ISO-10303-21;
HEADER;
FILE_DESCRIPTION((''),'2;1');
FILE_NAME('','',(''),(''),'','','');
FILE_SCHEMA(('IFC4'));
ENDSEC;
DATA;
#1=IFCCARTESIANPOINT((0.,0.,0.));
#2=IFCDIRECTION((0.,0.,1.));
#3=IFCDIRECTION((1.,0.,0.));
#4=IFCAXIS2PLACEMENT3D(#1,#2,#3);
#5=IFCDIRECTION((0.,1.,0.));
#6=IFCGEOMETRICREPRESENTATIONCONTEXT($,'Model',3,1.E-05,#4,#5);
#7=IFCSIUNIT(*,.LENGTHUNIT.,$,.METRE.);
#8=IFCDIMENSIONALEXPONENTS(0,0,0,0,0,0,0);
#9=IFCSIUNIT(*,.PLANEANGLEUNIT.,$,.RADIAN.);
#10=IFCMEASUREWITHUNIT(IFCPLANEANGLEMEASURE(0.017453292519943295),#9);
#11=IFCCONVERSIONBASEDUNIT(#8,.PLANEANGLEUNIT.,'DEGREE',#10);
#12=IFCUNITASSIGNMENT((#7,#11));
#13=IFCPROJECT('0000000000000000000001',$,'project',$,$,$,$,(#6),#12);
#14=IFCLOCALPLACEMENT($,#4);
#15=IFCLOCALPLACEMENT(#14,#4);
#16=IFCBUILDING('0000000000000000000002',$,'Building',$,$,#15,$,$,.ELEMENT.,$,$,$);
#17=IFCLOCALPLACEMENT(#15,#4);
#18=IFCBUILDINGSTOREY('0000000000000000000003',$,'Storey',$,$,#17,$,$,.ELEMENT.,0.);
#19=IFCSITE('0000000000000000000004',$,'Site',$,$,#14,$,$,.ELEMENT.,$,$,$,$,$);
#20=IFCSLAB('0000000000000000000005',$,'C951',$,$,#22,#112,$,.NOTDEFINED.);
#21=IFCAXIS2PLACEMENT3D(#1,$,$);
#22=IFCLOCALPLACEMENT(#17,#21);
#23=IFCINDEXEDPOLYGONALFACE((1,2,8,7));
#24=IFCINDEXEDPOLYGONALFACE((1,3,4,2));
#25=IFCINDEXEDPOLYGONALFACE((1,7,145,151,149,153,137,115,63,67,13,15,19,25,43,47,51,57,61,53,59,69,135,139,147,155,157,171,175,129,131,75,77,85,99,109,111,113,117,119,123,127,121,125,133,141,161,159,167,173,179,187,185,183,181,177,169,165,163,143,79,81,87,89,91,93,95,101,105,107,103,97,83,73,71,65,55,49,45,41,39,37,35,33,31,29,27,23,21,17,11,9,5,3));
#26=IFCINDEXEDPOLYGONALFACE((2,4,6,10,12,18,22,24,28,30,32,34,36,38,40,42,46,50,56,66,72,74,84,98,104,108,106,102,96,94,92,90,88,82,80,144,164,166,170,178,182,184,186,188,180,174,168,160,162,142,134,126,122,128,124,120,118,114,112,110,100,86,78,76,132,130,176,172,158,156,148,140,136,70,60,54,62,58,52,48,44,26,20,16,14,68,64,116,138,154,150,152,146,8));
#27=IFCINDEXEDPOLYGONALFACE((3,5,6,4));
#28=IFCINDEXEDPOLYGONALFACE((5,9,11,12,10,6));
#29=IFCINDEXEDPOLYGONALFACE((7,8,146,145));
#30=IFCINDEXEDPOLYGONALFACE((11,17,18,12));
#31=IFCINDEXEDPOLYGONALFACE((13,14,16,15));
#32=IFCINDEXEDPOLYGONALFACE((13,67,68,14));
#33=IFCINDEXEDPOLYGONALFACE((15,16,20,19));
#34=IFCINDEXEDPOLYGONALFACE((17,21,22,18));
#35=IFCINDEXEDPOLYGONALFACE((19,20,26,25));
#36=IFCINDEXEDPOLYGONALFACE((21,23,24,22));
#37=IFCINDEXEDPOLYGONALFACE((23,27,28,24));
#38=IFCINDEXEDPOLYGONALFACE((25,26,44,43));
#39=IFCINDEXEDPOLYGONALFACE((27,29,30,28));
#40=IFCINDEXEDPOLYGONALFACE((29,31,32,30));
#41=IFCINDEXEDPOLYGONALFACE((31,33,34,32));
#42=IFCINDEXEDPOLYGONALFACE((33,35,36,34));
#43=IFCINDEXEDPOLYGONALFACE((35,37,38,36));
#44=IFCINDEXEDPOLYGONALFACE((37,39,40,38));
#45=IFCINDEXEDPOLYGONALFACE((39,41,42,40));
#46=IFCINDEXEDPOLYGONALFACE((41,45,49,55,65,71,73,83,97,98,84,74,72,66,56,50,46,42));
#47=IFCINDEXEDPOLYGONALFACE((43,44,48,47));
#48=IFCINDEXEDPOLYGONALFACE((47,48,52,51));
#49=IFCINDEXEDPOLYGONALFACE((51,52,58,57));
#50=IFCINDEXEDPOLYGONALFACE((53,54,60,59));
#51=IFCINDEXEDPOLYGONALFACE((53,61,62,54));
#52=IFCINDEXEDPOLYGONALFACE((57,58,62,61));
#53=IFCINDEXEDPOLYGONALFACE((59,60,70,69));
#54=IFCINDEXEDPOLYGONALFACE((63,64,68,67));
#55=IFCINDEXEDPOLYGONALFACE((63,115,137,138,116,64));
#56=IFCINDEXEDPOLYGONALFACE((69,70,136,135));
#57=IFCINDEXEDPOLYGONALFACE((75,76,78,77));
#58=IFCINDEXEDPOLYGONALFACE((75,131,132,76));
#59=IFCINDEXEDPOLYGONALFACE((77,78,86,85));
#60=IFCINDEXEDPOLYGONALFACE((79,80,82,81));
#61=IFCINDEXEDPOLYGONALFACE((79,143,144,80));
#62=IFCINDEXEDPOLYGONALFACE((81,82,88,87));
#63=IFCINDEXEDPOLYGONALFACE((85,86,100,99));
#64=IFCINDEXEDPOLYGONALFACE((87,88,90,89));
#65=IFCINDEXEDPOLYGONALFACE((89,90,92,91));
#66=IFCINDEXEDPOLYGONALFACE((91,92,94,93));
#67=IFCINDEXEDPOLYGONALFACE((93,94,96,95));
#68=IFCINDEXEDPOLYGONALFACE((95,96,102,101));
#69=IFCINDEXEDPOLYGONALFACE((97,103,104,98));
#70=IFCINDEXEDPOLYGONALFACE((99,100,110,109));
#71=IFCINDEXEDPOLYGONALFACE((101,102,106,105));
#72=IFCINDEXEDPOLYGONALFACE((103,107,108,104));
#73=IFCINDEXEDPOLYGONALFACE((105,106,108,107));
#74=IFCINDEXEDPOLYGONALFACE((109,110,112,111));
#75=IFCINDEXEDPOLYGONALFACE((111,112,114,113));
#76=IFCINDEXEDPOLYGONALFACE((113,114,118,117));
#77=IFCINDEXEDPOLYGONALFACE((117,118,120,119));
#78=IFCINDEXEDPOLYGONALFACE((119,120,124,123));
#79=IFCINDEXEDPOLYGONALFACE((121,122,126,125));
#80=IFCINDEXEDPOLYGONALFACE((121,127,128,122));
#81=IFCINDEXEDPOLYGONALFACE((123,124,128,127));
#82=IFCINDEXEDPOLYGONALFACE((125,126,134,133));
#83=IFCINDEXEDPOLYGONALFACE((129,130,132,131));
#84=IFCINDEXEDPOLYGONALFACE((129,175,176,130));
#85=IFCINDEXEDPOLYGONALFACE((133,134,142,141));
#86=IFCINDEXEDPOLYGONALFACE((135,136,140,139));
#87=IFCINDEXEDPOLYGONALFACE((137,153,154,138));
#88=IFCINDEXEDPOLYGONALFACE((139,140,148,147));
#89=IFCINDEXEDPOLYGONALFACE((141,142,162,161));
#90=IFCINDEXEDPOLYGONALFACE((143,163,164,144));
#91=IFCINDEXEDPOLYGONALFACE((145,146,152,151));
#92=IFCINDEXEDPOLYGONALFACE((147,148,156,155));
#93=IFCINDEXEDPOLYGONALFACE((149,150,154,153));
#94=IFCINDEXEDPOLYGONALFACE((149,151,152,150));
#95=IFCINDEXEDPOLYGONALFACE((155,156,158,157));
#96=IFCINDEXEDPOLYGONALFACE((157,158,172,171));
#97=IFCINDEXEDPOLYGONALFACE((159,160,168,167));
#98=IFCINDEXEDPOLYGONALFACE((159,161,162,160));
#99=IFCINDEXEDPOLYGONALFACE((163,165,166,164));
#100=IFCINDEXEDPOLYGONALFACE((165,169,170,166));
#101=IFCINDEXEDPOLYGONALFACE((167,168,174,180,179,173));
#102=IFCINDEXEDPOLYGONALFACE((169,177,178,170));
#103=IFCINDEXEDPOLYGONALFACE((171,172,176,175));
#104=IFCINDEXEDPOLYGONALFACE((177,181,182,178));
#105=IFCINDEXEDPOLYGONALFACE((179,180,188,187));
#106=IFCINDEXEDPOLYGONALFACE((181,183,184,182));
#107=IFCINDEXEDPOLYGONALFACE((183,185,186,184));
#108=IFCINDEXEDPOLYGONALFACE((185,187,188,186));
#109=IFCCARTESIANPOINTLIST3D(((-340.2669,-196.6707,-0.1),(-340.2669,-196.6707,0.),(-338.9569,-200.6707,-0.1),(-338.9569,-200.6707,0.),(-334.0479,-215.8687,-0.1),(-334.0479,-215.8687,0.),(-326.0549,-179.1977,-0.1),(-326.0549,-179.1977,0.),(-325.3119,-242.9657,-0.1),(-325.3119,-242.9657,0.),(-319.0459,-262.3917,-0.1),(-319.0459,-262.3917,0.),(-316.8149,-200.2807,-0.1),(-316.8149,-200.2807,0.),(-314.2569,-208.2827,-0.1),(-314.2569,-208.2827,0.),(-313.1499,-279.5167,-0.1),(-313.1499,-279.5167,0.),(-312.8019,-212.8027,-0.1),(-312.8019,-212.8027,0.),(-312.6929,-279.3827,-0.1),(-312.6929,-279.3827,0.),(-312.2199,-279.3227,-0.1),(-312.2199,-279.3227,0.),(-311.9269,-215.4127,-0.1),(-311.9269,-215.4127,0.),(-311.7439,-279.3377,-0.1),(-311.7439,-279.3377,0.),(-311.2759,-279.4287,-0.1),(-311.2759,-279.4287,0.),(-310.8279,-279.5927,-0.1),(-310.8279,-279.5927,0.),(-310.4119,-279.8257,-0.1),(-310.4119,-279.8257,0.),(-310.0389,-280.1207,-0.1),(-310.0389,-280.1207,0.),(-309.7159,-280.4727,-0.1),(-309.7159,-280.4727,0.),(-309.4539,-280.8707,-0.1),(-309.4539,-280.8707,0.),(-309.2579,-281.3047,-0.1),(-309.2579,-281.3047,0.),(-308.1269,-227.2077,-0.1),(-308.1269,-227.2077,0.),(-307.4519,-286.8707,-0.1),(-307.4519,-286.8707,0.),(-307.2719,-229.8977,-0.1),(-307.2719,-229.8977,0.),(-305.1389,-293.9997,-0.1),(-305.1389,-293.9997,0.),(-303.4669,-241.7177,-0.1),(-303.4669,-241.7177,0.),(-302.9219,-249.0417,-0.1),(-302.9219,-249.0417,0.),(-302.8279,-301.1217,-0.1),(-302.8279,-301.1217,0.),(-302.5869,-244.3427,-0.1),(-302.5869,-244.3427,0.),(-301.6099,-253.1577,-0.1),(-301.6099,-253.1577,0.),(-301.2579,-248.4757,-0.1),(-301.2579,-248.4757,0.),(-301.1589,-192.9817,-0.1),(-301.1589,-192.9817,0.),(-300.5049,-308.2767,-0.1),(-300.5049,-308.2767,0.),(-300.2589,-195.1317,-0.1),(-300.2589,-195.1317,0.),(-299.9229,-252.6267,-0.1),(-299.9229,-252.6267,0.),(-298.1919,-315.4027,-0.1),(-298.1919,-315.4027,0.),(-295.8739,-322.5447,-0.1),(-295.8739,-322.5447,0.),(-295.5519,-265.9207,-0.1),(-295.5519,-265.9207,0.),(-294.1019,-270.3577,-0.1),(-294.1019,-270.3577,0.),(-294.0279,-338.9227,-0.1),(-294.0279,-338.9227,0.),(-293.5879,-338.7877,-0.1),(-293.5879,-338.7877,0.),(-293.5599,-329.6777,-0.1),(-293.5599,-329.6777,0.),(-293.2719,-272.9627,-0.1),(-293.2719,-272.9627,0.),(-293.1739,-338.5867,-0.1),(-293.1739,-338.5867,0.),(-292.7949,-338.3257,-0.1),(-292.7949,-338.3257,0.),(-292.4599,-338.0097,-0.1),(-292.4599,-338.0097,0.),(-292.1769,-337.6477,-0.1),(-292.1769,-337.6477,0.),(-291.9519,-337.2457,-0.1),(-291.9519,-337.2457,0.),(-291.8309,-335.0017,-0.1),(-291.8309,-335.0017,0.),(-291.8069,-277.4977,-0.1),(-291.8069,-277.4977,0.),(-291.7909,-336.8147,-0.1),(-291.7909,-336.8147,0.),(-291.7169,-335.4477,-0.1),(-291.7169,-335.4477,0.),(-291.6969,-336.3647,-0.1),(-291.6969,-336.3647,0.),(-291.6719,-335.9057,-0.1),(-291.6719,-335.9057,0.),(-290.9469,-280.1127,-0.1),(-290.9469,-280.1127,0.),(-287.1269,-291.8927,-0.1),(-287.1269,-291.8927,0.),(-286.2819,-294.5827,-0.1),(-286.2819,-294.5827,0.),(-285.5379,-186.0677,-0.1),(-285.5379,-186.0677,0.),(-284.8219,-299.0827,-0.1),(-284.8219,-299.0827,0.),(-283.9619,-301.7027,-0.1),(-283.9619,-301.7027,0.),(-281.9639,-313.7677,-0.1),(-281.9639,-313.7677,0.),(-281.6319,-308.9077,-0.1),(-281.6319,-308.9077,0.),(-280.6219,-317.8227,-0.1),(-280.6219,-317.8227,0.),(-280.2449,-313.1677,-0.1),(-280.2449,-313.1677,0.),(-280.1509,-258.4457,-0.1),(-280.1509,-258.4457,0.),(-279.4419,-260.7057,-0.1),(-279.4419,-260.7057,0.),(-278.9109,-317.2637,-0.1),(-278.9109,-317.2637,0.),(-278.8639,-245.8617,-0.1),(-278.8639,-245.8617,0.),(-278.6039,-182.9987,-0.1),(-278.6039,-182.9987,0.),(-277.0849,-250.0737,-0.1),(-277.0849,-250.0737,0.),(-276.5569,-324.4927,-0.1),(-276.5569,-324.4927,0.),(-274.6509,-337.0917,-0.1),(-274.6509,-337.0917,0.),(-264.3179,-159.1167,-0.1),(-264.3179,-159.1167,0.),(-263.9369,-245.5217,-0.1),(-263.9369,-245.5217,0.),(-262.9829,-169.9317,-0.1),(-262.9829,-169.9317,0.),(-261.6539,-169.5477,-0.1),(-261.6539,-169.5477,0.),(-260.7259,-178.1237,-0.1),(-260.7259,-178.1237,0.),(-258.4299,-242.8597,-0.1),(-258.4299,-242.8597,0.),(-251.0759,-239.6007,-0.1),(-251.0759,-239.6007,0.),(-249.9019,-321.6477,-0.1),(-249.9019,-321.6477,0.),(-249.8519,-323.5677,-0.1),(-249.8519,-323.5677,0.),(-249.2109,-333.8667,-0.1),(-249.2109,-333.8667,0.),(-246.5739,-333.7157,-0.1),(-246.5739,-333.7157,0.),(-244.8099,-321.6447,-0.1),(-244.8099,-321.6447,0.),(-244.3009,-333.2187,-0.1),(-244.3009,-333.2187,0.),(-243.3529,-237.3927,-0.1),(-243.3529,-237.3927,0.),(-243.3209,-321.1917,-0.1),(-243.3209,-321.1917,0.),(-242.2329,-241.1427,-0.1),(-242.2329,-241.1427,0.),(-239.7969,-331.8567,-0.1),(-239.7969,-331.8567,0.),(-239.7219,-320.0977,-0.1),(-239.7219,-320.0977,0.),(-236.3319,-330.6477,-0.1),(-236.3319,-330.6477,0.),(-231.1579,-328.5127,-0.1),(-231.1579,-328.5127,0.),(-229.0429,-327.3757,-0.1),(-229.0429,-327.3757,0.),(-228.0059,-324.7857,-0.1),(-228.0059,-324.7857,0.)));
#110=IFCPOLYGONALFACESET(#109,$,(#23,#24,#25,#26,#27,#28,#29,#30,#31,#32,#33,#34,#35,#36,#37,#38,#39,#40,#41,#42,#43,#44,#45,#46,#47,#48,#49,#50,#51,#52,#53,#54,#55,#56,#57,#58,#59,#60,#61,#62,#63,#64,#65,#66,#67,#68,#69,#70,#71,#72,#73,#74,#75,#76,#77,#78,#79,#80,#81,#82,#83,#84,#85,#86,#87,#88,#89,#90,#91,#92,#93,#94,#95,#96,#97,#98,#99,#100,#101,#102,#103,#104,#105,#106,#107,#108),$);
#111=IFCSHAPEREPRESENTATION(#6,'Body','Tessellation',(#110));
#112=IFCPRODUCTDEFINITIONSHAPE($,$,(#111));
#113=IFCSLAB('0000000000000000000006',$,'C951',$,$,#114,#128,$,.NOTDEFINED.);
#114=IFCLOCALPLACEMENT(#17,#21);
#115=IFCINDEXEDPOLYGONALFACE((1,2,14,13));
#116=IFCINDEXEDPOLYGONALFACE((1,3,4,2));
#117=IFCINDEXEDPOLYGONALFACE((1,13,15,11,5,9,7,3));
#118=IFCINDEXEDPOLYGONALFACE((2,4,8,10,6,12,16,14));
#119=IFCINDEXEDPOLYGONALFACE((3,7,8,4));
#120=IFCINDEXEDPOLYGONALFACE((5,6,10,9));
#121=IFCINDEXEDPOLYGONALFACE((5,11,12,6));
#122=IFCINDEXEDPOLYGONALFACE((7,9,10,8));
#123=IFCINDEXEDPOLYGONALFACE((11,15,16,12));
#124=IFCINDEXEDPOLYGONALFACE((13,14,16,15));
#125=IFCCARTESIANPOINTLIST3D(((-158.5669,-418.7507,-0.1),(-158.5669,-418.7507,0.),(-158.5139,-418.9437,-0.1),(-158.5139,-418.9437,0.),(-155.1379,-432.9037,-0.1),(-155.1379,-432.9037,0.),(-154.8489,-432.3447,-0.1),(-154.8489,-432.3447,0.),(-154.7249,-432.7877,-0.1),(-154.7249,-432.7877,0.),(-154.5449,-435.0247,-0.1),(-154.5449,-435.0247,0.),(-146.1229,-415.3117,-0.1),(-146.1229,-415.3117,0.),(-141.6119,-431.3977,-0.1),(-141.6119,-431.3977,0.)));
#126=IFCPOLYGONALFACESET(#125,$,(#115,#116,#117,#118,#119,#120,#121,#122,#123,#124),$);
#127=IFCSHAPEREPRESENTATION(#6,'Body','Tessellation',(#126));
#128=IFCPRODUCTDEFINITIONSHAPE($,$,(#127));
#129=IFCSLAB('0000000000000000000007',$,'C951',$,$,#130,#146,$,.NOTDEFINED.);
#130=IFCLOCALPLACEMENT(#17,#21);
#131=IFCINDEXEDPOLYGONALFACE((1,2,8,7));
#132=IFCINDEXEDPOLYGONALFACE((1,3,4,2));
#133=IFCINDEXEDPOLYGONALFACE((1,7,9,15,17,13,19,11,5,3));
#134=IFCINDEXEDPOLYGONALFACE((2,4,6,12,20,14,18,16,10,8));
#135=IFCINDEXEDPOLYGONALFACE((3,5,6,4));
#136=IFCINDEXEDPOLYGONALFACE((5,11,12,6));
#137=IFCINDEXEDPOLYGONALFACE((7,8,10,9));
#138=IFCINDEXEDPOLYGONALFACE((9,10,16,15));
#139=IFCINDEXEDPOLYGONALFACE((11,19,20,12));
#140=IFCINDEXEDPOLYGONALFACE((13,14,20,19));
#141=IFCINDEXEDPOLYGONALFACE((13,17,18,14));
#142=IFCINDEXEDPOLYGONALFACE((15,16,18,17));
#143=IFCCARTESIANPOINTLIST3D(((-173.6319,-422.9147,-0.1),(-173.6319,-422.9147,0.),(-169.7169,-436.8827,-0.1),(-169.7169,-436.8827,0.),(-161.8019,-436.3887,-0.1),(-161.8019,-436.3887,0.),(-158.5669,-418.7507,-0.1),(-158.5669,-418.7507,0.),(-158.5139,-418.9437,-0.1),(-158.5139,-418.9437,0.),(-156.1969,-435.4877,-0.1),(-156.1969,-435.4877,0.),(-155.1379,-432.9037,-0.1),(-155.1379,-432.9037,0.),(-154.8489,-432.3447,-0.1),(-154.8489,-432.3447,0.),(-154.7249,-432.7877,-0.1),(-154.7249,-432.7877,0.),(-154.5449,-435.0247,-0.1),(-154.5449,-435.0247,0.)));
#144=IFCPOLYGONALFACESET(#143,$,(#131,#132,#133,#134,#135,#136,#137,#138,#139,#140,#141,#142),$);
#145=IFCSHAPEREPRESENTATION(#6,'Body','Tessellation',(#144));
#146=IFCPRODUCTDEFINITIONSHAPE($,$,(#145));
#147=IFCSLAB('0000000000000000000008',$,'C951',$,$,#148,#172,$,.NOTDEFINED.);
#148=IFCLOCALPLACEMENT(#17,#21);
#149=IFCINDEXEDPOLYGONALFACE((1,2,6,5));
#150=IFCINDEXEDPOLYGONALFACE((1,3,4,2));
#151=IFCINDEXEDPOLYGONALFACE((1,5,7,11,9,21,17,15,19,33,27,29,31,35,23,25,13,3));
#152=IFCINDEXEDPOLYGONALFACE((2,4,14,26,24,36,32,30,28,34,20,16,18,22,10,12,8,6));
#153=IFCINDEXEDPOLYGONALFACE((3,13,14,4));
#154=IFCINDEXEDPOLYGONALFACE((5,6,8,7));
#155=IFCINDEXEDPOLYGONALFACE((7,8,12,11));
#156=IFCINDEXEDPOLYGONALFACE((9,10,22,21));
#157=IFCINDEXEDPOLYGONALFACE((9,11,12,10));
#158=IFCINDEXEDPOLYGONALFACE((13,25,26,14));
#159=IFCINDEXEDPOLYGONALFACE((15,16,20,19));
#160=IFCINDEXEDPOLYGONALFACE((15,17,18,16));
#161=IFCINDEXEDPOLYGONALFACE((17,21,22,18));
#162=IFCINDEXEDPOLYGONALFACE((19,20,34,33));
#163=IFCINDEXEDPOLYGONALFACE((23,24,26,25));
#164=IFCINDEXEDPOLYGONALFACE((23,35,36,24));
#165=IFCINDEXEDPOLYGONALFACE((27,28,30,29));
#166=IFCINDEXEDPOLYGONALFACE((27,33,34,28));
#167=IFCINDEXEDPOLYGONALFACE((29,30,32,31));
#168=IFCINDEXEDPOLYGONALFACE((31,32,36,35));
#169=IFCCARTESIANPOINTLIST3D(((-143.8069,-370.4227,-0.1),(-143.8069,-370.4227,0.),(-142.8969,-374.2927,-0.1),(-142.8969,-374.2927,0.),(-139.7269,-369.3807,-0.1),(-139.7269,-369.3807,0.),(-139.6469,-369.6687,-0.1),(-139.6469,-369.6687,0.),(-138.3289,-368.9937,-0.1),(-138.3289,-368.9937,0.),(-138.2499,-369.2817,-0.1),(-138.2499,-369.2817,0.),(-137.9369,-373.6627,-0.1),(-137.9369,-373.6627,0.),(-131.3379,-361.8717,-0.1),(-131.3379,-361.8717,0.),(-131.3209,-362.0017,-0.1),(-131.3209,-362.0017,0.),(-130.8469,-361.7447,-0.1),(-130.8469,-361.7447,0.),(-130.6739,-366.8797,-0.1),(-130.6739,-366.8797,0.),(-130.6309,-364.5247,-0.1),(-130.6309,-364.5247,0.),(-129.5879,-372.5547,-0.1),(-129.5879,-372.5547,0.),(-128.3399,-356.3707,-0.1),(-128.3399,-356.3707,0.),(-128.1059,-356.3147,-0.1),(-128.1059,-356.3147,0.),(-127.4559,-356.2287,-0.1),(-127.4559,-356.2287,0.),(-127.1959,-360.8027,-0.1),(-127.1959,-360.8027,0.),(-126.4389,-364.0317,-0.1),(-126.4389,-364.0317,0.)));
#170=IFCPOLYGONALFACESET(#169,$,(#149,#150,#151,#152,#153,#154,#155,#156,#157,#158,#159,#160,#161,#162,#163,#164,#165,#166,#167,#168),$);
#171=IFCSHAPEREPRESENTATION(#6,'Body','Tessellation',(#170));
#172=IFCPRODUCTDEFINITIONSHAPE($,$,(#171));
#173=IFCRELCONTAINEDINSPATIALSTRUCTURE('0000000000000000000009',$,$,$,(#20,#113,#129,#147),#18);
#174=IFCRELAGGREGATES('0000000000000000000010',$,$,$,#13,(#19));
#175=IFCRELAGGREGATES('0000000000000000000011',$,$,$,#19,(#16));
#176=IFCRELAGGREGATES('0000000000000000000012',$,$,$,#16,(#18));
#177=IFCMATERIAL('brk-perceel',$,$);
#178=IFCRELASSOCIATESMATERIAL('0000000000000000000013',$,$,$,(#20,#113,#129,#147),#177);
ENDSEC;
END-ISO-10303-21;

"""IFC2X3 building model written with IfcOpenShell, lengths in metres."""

from ifc_helpers import new_model, entity, si_unit, converted_unit, direction, frame, origin_with_axes, place, context, project, spatial, polyline, outline, extrude, material, element, save


model = new_model("IFC2X3")

# Units and contexts
model_context = context("Model", 3, precision=1e-05, world=origin_with_axes(), true_north=direction((0.0, 1.0, 0.0)))
ifc_project = project(units=[si_unit("LENGTHUNIT", "METRE"), converted_unit("PLANEANGLEUNIT", "DEGREE", entity("IfcPlaneAngleMeasure", 0.017453292519943295), si_unit("PLANEANGLEUNIT", "RADIAN"), dimensions=[0, 0, 0, 0, 0, 0, 0])], contexts=[model_context])

# Site, building, storey
site_placement = place(None, origin_with_axes())
site = spatial("IfcSite", under=ifc_project, at=site_placement, Name="Site", CompositionType="ELEMENT")
building_placement = place(site_placement, origin_with_axes())
building = spatial("IfcBuilding", under=site, at=building_placement, Name="Building", CompositionType="ELEMENT")
storey_placement = place(building_placement, origin_with_axes())
storey = spatial("IfcBuildingStorey", under=building, at=storey_placement, Name="Storey", CompositionType="ELEMENT", Elevation=0.0)

# Slabs
ifc_material = material(Name="brk-perceel")
slab_1_placement = place(storey_placement, frame((0.0, 0.0, -0.1), z_axis=(0.0, 0.0, 1.0), x_axis=(1.0, 0.0, 0.0)))
element("IfcSlab", 1, at=slab_1_placement, inside=storey, material=ifc_material, Name="C951", PredefinedType="NOTDEFINED", context=model_context, shape_type="SweptSolid", body=[
    extrude(outline(polyline([(-239.7219, -320.0977), (-228.0059, -324.7857), (-229.0429, -327.3757), (-231.1579, -328.5127), (-236.3319, -330.6477), (-239.7969, -331.8567), (-244.3009, -333.2187), (-246.5739, -333.7157), (-249.2109, -333.8667), (-274.6509, -337.0917), (-294.0279, -338.9227), (-293.5879, -338.7877), (-293.1739, -338.5867), (-292.7949, -338.3257), (-292.4599, -338.0097), (-292.1769, -337.6477), (-291.9519, -337.2457), (-291.7909, -336.8147), (-291.6969, -336.3647), (-291.6719, -335.9057), (-291.7169, -335.4477), (-291.8309, -335.0017), (-293.5599, -329.6777), (-295.8739, -322.5447), (-298.1919, -315.4027), (-300.5049, -308.2767), (-302.8279, -301.1217), (-305.1389, -293.9997), (-307.4519, -286.8707), (-309.2579, -281.3047), (-309.4539, -280.8707), (-309.7159, -280.4727), (-310.0389, -280.1207), (-310.4119, -279.8257), (-310.8279, -279.5927), (-311.2759, -279.4287), (-311.7439, -279.3377), (-312.2199, -279.3227), (-312.6929, -279.3827), (-313.1499, -279.5167), (-319.0459, -262.3917), (-325.3119, -242.9657), (-334.0479, -215.8687), (-338.9569, -200.6707), (-340.2669, -196.6707), (-326.0549, -179.1977), (-264.3179, -159.1167), (-261.6539, -169.5477), (-262.9829, -169.9317), (-260.7259, -178.1237), (-278.6039, -182.9987), (-285.5379, -186.0677), (-301.1589, -192.9817), (-300.2589, -195.1317), (-316.8149, -200.2807), (-314.2569, -208.2827), (-312.8019, -212.8027), (-311.9269, -215.4127), (-308.1269, -227.2077), (-307.2719, -229.8977), (-303.4669, -241.7177), (-302.5869, -244.3427), (-301.2579, -248.4757), (-302.9219, -249.0417), (-301.6099, -253.1577), (-299.9229, -252.6267), (-278.8639, -245.8617), (-277.0849, -250.0737), (-263.9369, -245.5217), (-258.4299, -242.8597), (-251.0759, -239.6007), (-243.3529, -237.3927), (-242.2329, -241.1427), (-280.1509, -258.4457), (-279.4419, -260.7057), (-295.5519, -265.9207), (-294.1019, -270.3577), (-293.2719, -272.9627), (-291.8069, -277.4977), (-290.9469, -280.1127), (-287.1269, -291.8927), (-286.2819, -294.5827), (-284.8219, -299.0827), (-283.9619, -301.7027), (-281.6319, -308.9077), (-280.2449, -313.1677), (-281.9639, -313.7677), (-280.6219, -317.8227), (-278.9109, -317.2637), (-276.5569, -324.4927), (-249.8519, -323.5677), (-249.9019, -321.6477), (-244.8099, -321.6447), (-243.3209, -321.1917), (-239.7219, -320.0977)])), origin_with_axes(), (0.0, 0.0, 1.0), 0.1),
])
slab_2_placement = place(storey_placement, frame((0.0, 0.0, -0.1), z_axis=(0.0, 0.0, 1.0), x_axis=(1.0, 0.0, 0.0)))
element("IfcSlab", 2, at=slab_2_placement, inside=storey, material=ifc_material, Name="C951", PredefinedType="NOTDEFINED", context=model_context, shape_type="SweptSolid", body=[
    extrude(outline(polyline([(-146.1229, -415.3117), (-141.6119, -431.3977), (-154.5449, -435.0247), (-155.1379, -432.9037), (-154.7249, -432.7877), (-154.8489, -432.3447), (-158.5139, -418.9437), (-158.5669, -418.7507), (-146.1229, -415.3117)])), origin_with_axes(), (0.0, 0.0, 1.0), 0.1),
])
slab_3_placement = place(storey_placement, frame((0.0, 0.0, -0.1), z_axis=(0.0, 0.0, 1.0), x_axis=(1.0, 0.0, 0.0)))
element("IfcSlab", 3, at=slab_3_placement, inside=storey, material=ifc_material, Name="C951", PredefinedType="NOTDEFINED", context=model_context, shape_type="SweptSolid", body=[
    extrude(outline(polyline([(-158.5139, -418.9437), (-154.8489, -432.3447), (-154.7249, -432.7877), (-155.1379, -432.9037), (-154.5449, -435.0247), (-156.1969, -435.4877), (-161.8019, -436.3887), (-169.7169, -436.8827), (-173.6319, -422.9147), (-158.5669, -418.7507), (-158.5139, -418.9437)])), origin_with_axes(), (0.0, 0.0, 1.0), 0.1),
])
slab_4_placement = place(storey_placement, frame((0.0, 0.0, -0.1), z_axis=(0.0, 0.0, 1.0), x_axis=(1.0, 0.0, 0.0)))
element("IfcSlab", 4, at=slab_4_placement, inside=storey, material=ifc_material, Name="C951", PredefinedType="NOTDEFINED", context=model_context, shape_type="SweptSolid", body=[
    extrude(outline(polyline([(-137.9369, -373.6627), (-142.8969, -374.2927), (-143.8069, -370.4227), (-139.7269, -369.3807), (-139.6469, -369.6687), (-138.2499, -369.2817), (-138.3289, -368.9937), (-130.6739, -366.8797), (-131.3209, -362.0017), (-131.3379, -361.8717), (-130.8469, -361.7447), (-127.1959, -360.8027), (-128.3399, -356.3707), (-128.1059, -356.3147), (-127.4559, -356.2287), (-126.4389, -364.0317), (-130.6309, -364.5247), (-129.5879, -372.5547), (-137.9369, -373.6627)])), origin_with_axes(), (0.0, 0.0, 1.0), 0.1),
])

save(model, "model.ifc")
